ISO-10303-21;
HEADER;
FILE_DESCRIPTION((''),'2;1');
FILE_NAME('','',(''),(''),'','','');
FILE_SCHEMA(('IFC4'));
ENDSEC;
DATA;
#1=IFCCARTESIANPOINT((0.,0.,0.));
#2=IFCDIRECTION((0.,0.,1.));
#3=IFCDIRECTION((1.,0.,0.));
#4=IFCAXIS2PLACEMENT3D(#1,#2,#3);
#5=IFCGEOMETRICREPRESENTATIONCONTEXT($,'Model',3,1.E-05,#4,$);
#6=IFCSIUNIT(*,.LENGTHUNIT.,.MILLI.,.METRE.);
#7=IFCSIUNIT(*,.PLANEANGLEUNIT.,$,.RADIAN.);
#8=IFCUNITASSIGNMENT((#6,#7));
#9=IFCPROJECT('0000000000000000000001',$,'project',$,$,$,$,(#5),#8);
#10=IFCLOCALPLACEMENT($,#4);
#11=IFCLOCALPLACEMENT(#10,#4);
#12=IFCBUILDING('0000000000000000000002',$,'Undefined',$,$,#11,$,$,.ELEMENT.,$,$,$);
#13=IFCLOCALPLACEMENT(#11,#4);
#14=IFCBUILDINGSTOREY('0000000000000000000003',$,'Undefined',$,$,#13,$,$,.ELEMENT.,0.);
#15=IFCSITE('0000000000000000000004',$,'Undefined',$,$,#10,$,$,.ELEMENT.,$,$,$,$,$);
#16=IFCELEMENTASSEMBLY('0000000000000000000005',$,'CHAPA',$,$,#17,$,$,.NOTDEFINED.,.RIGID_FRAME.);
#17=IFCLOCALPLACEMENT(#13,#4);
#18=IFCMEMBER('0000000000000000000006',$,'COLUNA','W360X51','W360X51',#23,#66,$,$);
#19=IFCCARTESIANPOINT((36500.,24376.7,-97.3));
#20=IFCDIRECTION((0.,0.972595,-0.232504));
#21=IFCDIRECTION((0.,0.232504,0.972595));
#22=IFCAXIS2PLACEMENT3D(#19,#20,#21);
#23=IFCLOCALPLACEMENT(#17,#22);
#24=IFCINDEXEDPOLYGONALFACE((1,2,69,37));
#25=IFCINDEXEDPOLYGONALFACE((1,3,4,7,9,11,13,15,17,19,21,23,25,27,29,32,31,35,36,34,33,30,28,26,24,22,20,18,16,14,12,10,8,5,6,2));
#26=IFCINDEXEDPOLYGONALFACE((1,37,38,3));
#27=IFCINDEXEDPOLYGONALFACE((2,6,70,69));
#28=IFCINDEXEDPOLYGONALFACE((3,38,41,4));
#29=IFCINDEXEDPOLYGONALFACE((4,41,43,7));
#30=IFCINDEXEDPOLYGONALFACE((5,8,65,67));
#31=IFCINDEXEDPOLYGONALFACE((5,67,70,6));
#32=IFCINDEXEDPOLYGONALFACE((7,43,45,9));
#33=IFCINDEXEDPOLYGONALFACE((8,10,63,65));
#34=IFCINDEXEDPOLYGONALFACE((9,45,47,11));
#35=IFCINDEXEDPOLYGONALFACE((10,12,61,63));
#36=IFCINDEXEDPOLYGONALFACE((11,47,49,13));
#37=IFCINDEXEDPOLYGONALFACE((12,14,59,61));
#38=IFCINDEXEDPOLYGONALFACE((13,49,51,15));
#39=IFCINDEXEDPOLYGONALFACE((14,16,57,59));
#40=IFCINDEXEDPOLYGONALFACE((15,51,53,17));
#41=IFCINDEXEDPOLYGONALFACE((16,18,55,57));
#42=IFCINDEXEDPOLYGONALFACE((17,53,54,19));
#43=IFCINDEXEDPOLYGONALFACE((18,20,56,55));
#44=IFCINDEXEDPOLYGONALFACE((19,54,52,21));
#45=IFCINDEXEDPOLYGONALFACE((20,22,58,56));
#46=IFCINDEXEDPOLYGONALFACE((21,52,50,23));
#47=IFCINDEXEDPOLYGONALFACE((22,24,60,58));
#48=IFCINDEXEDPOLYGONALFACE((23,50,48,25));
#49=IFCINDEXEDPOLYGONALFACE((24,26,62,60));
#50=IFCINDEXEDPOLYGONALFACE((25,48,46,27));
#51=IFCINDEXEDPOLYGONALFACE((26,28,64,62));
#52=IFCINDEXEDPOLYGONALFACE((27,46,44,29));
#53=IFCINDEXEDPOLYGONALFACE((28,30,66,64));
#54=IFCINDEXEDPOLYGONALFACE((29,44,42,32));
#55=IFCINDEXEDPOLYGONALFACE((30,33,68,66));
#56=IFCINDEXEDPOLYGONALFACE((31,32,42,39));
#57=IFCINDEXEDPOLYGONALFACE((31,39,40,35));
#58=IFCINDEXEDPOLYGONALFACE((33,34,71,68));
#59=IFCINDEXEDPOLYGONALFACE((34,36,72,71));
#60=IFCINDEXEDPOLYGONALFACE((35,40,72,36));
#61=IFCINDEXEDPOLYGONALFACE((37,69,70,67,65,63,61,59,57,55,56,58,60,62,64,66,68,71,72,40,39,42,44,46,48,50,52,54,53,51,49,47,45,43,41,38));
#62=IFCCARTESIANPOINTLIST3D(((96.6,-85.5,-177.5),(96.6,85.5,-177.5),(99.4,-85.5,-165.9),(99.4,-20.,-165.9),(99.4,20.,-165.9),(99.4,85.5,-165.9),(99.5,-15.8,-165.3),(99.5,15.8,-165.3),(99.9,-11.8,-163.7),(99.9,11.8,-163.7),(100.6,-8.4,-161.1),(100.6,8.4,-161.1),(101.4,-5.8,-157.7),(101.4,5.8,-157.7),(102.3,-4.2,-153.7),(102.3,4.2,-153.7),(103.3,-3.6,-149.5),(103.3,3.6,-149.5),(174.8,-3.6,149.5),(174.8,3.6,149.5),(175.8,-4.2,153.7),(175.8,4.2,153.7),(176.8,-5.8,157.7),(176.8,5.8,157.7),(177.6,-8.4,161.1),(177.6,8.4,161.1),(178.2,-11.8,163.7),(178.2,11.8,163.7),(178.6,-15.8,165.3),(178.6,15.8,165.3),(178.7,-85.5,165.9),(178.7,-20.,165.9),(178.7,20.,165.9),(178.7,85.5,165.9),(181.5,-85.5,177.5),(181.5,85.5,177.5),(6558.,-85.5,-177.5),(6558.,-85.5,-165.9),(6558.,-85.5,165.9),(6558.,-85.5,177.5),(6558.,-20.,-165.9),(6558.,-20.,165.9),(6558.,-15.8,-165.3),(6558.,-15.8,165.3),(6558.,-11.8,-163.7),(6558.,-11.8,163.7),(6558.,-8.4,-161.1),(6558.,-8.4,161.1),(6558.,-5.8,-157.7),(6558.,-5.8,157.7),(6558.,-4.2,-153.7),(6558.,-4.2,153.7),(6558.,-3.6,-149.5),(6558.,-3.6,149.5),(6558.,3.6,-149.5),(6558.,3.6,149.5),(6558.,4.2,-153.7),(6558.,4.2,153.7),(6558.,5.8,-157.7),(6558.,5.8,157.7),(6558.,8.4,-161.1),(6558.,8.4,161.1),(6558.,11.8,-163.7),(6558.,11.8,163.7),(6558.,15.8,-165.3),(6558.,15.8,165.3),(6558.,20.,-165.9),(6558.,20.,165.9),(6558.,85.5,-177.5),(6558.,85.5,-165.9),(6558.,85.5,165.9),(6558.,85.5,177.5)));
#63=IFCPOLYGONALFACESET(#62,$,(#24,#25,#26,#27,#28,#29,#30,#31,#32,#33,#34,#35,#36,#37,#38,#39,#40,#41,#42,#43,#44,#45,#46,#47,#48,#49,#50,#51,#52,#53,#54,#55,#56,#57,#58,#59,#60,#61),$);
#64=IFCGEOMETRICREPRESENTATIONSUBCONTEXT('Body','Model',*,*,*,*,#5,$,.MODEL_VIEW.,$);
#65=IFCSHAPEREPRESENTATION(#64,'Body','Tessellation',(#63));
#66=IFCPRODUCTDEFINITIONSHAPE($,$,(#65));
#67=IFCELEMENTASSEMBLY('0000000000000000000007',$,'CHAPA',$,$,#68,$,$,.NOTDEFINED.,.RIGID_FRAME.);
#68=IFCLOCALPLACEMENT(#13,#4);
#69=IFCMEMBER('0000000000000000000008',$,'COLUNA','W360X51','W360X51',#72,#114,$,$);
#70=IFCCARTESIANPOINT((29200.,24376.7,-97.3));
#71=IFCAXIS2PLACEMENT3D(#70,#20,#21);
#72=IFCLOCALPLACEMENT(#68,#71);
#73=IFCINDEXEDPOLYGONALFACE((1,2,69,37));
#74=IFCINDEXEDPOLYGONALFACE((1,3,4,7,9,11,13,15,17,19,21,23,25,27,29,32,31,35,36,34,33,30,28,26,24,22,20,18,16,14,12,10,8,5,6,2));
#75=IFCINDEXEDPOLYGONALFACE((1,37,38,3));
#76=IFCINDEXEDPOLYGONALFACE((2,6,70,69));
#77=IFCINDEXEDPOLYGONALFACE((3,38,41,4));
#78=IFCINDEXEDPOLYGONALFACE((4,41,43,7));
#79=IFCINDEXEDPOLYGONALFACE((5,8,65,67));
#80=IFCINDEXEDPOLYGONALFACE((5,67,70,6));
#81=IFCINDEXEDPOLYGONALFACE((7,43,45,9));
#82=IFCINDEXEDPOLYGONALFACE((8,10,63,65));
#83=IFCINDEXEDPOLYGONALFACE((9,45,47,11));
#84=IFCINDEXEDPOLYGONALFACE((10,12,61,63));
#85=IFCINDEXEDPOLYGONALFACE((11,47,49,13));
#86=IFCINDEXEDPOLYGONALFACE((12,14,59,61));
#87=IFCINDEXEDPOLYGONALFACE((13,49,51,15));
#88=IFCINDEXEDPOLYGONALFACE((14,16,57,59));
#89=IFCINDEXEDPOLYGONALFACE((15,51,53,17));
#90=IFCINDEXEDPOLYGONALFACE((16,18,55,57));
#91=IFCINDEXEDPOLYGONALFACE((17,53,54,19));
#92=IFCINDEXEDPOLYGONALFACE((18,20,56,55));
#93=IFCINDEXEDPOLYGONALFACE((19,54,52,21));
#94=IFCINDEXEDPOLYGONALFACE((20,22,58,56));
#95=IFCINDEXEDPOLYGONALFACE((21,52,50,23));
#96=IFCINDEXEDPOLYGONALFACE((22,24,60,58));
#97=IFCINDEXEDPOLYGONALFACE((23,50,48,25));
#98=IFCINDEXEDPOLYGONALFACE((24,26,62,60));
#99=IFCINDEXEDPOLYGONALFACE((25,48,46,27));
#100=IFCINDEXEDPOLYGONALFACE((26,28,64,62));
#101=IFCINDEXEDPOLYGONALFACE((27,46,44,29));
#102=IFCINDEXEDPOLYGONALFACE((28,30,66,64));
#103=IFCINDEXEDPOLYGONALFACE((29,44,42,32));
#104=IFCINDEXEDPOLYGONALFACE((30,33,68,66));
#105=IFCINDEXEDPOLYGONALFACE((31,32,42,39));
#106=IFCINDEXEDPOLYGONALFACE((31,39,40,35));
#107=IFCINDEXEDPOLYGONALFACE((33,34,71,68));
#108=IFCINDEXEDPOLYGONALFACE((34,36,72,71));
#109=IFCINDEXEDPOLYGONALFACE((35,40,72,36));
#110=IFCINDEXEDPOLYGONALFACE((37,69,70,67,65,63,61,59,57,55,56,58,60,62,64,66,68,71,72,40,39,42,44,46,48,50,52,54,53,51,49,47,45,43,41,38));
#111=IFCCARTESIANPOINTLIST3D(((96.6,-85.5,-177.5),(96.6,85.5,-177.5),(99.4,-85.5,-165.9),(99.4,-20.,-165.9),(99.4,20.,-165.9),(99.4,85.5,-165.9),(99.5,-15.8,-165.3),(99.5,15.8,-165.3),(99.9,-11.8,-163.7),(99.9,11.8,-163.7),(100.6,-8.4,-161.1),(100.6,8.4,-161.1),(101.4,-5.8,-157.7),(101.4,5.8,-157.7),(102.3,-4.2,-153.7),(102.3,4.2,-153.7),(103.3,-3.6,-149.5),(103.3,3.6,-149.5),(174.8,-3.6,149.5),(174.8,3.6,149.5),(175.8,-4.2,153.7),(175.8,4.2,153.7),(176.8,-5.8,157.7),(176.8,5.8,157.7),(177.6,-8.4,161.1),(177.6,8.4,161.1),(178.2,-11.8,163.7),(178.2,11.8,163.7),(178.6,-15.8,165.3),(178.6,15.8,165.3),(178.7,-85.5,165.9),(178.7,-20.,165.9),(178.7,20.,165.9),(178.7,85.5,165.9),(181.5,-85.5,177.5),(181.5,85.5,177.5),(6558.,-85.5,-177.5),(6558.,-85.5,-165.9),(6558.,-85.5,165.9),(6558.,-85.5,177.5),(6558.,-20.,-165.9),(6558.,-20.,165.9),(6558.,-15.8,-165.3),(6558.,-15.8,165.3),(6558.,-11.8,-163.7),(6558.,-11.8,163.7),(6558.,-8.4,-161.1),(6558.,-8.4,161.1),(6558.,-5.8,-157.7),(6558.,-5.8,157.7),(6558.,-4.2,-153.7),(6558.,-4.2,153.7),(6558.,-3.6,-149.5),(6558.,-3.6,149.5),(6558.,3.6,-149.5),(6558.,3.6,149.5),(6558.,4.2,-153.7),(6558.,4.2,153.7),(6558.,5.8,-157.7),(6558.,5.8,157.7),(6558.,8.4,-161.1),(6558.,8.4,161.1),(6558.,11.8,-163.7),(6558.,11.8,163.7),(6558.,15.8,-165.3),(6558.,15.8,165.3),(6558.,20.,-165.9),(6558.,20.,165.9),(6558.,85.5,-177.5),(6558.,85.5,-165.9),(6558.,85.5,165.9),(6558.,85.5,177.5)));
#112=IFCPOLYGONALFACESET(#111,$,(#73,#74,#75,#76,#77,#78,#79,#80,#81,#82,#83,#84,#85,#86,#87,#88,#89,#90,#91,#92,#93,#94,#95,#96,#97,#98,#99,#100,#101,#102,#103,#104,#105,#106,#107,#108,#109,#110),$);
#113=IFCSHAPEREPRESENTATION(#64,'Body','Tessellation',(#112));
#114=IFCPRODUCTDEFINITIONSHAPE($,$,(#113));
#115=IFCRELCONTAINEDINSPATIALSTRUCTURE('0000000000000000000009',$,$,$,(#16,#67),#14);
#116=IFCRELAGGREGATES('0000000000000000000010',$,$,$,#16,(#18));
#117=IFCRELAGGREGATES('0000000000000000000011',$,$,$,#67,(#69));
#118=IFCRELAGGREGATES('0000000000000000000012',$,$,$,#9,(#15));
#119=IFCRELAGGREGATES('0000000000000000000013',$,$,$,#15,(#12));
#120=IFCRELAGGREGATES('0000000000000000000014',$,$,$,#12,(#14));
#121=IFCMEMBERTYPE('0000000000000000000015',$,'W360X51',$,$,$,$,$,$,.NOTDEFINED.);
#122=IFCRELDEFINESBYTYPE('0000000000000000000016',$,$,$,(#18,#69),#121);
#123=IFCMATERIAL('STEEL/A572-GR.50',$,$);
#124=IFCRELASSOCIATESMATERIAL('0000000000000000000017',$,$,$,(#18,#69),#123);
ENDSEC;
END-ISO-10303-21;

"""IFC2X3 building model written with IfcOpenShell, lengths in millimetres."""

from ifc_helpers import new_model, si_unit, frame, origin_with_axes, origin_2d_with_axis, place, context, subcontext, project, spatial, i_section, extrude, clip, halfspace, material, type_object, element, aggregate, save


model = new_model("IFC2X3")

# Units and contexts
model_context = context("Model", 3, precision=1e-05, world=origin_with_axes())
body_context = subcontext(model_context, "Body", "Model", "MODEL_VIEW")
ifc_project = project(units=[si_unit("LENGTHUNIT", "METRE", prefix="MILLI"), si_unit("PLANEANGLEUNIT", "RADIAN")], contexts=[model_context])

# Site, building, storey
site_placement = place(None, origin_with_axes())
site = spatial("IfcSite", under=ifc_project, at=site_placement, Name="Undefined", CompositionType="ELEMENT")
building_placement = place(site_placement, origin_with_axes())
building = spatial("IfcBuilding", under=site, at=building_placement, Name="Undefined", CompositionType="ELEMENT")
storey_placement = place(building_placement, origin_with_axes())
storey = spatial("IfcBuildingStorey", under=building, at=storey_placement, Name="Undefined", CompositionType="ELEMENT", Elevation=0.0)

# Shared definitions
ifc_material_1 = material(Name="STEEL/A572-GR.50")

# Element assemblies, members
assembly_1_placement = place(storey_placement, origin_with_axes())
assembly_1 = element("IfcElementAssembly", 1, at=assembly_1_placement, inside=storey, Name="CHAPA", AssemblyPlace="NOTDEFINED", PredefinedType="RIGID_FRAME")
member_type = type_object("IfcMemberType", Name="W360X51", PredefinedType="NOTDEFINED")
member_1_placement = place(assembly_1_placement, frame((36500.0, 24376.7, -97.3), z_axis=(0.0, 0.972595, -0.232504), x_axis=(0.0, 0.232504, 0.972595)))
member_1 = element("IfcMember", 2, at=member_1_placement, type_object=member_type, material=ifc_material_1, Name="COLUNA", Description="W360X51", ObjectType="W360X51", context=body_context, shape_type="Clipping", body=[
    clip(clip(extrude(i_section(OverallWidth=171.0, OverallDepth=355.0, WebThickness=7.2, FlangeThickness=11.6, FilletRadius=16.4, at=origin_2d_with_axis()), frame((6558.0, 0.0, 0.0), z_axis=(-1.0, 0.0, 0.0), x_axis=(0.0, -1.0, 0.0)), (0.0, 0.0, 1.0), 6542.9), halfspace(frame((94.5, -85.5, -186.3), z_axis=(-0.972595, 0.0, 0.232504), x_axis=(0.0, 1.0, 0.0)), False)), halfspace(frame((96.6, 0.0, -177.5), z_axis=(0.972595, 0.0, -0.232504), x_axis=(0.0, -1.0, 0.0)), True)),
])
assembly_2_placement = place(storey_placement, origin_with_axes())
assembly_2 = element("IfcElementAssembly", 3, at=assembly_2_placement, inside=storey, Name="CHAPA", AssemblyPlace="NOTDEFINED", PredefinedType="RIGID_FRAME")
member_2_placement = place(assembly_2_placement, frame((29200.0, 24376.7, -97.3), z_axis=(0.0, 0.972595, -0.232504), x_axis=(0.0, 0.232504, 0.972595)))
member_2 = element("IfcMember", 4, at=member_2_placement, type_object=member_type, material=ifc_material_1, Name="COLUNA", Description="W360X51", ObjectType="W360X51", context=body_context, shape_type="Clipping", body=[
    clip(clip(extrude(i_section(OverallWidth=171.0, OverallDepth=355.0, WebThickness=7.2, FlangeThickness=11.6, FilletRadius=16.4, at=origin_2d_with_axis()), frame((6558.0, 0.0, 0.0), z_axis=(-1.0, 0.0, 0.0), x_axis=(0.0, -1.0, 0.0)), (0.0, 0.0, 1.0), 6542.9), halfspace(frame((94.5, -85.5, -186.3), z_axis=(-0.972595, 0.0, 0.232504), x_axis=(0.0, 1.0, 0.0)), False)), halfspace(frame((96.6, 0.0, -177.5), z_axis=(0.972595, 0.0, -0.232504), x_axis=(0.0, -1.0, 0.0)), True)),
])

aggregate(assembly_1, [member_1])
aggregate(assembly_2, [member_2])

save(model, "model.ifc")
